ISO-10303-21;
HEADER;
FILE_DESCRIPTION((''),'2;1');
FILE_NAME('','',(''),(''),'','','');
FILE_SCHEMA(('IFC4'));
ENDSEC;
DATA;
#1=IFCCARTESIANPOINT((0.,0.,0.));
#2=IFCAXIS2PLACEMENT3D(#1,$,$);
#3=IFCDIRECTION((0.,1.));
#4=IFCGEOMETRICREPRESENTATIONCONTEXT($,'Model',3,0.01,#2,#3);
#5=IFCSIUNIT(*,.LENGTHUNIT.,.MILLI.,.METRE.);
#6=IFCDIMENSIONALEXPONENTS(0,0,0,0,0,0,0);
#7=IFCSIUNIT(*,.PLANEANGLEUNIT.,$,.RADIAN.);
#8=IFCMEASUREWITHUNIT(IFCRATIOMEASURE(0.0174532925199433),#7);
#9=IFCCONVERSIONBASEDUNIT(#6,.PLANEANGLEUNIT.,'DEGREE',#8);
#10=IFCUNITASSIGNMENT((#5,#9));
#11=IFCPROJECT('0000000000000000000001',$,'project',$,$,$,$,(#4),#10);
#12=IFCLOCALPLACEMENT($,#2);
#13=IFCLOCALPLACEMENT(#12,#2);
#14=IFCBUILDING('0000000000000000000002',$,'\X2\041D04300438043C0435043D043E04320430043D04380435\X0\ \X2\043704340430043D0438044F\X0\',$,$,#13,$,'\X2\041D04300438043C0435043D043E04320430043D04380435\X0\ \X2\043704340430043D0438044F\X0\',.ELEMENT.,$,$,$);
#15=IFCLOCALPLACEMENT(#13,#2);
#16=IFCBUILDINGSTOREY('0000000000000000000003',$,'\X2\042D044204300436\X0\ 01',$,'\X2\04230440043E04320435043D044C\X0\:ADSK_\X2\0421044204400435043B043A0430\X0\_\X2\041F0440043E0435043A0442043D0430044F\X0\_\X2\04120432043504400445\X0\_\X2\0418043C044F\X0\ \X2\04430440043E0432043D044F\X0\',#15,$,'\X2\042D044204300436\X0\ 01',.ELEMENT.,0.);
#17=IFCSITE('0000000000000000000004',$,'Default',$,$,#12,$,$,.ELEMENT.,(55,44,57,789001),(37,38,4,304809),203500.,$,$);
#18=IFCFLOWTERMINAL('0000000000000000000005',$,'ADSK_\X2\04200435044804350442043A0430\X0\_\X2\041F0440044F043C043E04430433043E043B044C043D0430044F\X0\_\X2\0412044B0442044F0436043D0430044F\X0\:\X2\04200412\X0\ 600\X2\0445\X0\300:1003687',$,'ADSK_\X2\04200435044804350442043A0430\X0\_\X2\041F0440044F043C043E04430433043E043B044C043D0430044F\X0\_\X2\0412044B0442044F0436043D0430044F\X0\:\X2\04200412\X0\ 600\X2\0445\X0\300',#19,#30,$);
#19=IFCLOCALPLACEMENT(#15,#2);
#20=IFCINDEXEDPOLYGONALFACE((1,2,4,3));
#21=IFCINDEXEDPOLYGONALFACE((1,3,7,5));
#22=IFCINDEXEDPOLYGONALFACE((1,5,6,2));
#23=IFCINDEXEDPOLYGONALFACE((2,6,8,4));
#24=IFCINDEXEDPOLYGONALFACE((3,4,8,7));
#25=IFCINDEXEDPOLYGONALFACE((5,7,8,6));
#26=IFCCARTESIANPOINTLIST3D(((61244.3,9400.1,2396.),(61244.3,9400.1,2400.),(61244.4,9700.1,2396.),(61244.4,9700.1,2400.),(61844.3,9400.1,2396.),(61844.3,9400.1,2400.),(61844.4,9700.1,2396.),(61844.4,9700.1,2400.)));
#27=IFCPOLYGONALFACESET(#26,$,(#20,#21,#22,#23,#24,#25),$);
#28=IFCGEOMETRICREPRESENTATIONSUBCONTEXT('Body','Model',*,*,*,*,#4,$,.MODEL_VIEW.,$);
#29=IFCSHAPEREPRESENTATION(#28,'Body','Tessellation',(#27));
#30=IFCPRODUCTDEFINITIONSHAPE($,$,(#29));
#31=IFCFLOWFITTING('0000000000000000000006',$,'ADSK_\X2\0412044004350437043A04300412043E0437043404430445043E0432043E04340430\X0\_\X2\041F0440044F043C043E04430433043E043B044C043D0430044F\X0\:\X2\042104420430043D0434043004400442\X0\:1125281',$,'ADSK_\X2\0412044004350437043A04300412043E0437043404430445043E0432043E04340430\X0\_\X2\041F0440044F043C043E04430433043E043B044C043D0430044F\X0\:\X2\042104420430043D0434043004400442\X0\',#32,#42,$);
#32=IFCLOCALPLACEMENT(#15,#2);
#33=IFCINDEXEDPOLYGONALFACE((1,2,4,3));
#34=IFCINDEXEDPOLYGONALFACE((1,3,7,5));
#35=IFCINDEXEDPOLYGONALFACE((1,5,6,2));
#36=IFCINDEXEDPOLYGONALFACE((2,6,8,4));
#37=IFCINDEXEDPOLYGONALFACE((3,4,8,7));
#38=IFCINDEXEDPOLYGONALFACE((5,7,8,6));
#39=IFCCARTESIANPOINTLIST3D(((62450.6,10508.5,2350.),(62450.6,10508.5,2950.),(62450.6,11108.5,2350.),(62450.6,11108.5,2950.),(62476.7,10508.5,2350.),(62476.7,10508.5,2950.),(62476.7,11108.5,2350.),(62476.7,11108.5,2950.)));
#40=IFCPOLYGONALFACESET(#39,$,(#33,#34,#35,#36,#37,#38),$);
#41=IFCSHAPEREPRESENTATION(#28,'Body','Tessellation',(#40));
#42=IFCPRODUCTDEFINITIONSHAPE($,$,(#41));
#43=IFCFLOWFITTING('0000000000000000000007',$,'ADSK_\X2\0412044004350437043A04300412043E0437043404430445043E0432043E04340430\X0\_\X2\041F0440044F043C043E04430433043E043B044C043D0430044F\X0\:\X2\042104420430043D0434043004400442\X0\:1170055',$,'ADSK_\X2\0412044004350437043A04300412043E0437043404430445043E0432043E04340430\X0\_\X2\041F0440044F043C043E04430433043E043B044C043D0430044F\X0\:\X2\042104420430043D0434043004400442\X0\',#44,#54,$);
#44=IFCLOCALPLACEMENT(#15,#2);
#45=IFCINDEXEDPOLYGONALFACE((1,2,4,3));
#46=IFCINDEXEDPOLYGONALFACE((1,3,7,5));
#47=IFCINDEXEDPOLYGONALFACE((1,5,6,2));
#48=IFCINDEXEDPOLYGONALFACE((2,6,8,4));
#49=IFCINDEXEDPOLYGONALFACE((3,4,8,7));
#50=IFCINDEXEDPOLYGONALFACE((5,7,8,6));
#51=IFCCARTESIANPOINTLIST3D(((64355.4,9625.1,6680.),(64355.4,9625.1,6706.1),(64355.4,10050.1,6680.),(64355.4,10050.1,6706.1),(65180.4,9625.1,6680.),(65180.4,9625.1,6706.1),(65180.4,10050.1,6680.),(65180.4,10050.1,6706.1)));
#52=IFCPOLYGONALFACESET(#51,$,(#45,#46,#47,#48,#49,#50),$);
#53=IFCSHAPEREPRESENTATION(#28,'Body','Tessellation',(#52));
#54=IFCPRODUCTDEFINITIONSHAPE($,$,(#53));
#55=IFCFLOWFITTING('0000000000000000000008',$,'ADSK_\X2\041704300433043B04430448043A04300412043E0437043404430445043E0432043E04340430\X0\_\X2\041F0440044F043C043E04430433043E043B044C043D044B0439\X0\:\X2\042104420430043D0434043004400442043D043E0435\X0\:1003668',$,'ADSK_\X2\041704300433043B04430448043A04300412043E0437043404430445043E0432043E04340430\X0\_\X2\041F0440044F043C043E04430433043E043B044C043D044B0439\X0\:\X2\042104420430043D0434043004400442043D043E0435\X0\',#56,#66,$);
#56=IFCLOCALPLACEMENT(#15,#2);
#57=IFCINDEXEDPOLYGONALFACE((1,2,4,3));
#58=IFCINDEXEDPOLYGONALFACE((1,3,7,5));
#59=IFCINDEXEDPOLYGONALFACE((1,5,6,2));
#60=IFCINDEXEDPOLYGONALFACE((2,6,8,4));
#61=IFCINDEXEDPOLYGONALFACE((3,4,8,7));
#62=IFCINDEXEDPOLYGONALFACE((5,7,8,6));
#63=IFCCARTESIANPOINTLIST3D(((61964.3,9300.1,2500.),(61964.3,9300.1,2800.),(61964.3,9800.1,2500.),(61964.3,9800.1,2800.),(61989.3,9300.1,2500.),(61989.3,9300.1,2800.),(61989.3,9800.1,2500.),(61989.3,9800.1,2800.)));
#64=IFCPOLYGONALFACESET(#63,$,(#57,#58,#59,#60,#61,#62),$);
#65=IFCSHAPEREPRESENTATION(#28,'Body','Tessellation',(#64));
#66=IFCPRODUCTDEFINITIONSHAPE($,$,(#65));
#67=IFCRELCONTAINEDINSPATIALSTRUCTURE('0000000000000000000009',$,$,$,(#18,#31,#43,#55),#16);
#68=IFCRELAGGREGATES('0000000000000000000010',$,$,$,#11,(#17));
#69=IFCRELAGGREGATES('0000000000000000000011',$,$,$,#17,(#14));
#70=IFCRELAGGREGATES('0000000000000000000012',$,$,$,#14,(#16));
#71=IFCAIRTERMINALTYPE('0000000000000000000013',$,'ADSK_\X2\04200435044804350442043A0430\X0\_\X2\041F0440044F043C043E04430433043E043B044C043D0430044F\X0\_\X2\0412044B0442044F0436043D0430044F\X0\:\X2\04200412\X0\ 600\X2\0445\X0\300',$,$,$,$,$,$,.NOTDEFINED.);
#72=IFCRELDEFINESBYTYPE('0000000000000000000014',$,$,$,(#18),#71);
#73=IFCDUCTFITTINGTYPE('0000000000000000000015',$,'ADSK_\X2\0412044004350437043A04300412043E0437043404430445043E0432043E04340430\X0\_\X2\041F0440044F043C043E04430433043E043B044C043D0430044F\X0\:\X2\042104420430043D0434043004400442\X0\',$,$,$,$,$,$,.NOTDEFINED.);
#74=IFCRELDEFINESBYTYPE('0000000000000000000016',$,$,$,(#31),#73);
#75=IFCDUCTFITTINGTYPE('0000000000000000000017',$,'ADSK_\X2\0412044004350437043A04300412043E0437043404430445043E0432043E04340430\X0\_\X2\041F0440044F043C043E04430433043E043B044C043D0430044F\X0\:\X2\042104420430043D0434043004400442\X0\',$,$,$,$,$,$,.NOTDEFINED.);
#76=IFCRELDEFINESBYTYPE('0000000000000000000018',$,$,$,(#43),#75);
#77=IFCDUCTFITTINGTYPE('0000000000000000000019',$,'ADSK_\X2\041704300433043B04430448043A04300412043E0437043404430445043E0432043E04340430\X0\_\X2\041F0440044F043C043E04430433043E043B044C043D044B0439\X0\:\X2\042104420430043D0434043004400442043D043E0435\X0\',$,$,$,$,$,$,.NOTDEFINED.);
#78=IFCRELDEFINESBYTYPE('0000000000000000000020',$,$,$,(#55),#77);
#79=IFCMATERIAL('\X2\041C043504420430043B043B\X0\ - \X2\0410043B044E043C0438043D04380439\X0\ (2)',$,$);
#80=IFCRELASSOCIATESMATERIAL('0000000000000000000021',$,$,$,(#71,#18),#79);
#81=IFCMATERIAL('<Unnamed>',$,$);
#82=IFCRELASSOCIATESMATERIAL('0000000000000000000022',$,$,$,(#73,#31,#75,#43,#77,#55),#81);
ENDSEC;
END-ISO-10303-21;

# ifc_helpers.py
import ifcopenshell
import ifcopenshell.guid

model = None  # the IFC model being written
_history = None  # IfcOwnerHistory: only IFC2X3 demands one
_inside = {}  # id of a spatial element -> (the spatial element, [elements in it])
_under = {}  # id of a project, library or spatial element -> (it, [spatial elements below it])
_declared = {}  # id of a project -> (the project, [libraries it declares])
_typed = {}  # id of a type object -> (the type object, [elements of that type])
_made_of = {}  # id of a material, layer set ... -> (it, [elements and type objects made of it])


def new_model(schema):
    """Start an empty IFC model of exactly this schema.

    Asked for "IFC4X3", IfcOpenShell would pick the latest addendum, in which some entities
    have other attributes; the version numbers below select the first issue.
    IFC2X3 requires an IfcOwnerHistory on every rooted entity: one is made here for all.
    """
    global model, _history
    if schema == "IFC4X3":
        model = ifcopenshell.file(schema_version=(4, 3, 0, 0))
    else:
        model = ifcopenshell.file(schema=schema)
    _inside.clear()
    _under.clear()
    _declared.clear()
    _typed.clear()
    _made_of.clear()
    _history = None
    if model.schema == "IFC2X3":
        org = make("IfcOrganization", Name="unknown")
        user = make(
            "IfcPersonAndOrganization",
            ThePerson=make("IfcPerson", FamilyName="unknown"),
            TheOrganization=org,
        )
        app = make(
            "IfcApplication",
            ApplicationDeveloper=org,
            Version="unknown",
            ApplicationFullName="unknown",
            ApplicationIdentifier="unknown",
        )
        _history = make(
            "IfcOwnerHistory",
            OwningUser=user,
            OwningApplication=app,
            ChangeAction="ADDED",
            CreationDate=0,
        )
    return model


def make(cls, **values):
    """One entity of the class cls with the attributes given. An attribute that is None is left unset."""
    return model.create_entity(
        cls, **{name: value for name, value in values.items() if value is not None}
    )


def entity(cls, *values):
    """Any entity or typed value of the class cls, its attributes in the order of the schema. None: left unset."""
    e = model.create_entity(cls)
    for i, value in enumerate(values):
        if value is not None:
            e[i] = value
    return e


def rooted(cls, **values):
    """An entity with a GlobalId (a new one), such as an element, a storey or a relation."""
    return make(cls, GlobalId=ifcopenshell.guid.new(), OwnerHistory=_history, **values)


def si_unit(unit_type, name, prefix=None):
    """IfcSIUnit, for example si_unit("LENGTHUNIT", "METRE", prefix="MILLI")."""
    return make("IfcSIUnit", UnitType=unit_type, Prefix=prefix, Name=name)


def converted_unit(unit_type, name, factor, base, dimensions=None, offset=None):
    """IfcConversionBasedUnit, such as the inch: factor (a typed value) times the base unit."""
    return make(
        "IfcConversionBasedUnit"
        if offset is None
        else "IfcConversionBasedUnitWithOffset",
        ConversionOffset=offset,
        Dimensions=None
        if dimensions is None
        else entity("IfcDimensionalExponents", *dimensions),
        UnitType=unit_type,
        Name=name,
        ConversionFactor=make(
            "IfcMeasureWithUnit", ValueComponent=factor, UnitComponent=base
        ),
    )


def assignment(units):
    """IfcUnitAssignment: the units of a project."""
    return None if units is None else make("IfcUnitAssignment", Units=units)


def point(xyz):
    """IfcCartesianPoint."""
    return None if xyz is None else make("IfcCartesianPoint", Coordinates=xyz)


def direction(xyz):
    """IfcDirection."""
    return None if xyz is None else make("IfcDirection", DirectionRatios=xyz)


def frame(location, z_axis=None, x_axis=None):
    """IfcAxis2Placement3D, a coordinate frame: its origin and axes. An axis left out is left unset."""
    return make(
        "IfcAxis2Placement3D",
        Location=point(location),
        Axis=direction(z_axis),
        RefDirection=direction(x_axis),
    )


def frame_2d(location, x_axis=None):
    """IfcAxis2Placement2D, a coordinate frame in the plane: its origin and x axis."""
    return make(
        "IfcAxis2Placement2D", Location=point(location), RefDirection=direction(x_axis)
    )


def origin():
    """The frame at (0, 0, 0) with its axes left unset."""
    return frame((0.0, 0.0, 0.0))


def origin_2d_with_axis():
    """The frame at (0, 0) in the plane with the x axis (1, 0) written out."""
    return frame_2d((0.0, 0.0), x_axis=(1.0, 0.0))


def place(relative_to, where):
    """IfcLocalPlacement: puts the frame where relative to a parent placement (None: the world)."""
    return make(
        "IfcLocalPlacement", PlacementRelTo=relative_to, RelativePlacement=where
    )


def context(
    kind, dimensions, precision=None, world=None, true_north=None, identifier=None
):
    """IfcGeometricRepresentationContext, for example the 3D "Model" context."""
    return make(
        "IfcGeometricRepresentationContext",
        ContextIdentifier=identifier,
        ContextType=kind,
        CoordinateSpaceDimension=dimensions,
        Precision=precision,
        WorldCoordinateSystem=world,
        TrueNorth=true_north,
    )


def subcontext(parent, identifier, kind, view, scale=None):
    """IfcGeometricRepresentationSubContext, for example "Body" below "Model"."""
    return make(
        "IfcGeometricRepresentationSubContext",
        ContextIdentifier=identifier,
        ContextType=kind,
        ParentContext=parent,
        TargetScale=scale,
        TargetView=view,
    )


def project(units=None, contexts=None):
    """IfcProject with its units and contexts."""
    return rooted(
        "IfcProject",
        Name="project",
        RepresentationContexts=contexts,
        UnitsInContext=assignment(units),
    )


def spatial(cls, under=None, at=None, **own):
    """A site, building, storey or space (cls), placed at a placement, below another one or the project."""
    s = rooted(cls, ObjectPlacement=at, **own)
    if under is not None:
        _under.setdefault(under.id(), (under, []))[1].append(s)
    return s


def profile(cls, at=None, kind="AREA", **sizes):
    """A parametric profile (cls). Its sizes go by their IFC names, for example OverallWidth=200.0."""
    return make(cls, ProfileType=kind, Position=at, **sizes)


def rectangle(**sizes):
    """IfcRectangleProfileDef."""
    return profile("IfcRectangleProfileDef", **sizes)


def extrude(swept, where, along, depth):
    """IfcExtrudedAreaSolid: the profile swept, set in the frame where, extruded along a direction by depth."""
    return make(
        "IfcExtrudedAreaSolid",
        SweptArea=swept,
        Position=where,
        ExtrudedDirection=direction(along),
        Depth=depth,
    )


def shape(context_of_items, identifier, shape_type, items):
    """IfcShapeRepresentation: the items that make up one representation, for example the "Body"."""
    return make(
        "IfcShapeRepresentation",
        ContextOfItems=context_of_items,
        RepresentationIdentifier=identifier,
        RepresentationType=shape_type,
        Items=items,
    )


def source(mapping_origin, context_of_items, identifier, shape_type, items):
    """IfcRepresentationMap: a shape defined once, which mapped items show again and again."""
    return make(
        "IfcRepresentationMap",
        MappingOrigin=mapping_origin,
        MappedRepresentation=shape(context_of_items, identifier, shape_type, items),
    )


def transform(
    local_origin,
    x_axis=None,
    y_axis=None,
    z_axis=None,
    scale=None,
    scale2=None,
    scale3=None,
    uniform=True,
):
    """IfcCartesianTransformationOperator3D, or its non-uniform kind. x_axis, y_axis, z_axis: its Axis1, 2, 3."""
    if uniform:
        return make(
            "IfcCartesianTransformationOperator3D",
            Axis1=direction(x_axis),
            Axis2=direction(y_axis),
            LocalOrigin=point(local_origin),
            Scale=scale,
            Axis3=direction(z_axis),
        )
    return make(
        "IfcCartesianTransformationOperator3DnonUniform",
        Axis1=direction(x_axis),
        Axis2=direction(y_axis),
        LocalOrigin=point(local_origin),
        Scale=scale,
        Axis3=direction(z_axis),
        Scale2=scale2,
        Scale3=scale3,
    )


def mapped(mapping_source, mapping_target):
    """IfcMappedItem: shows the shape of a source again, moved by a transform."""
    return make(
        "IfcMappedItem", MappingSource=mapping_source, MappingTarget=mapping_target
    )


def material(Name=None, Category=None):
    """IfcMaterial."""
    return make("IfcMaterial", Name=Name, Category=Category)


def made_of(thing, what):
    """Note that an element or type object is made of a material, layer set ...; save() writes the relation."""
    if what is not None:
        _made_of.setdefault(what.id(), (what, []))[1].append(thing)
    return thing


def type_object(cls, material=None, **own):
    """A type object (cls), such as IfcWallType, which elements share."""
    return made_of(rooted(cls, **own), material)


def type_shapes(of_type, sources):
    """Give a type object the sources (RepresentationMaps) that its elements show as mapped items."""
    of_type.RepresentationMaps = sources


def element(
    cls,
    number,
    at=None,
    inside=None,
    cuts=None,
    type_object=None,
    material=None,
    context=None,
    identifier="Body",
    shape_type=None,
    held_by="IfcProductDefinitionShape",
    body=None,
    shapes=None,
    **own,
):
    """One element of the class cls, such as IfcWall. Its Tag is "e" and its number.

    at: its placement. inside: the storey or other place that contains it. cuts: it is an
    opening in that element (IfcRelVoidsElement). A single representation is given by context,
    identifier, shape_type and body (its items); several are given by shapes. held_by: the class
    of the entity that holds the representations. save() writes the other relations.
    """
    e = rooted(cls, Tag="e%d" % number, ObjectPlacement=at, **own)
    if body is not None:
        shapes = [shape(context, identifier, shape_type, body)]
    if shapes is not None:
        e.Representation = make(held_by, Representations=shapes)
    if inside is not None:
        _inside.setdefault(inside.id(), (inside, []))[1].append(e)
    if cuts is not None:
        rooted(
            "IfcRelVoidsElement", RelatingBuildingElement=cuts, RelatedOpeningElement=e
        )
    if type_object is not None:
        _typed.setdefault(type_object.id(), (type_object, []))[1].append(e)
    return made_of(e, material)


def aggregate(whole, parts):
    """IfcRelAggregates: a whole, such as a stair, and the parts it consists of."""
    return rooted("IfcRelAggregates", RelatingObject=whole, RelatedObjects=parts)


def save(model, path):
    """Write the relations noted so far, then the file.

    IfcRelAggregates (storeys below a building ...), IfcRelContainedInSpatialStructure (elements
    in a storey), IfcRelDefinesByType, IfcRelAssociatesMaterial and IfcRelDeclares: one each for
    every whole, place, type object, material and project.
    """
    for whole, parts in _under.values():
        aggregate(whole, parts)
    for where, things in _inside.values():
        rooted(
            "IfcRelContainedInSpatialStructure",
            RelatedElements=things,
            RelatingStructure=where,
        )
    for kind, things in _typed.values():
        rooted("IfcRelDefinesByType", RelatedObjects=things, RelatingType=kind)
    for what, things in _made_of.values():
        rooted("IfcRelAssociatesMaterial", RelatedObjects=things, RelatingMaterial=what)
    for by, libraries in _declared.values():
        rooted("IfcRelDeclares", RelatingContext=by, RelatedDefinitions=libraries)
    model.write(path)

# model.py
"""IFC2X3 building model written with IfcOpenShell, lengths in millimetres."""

from ifc_helpers import new_model, entity, si_unit, converted_unit, direction, frame, origin, origin_2d_with_axis, place, context, subcontext, project, spatial, rectangle, extrude, source, transform, mapped, material, type_object, type_shapes, element, save


model = new_model("IFC2X3")

# Units and contexts
model_context = context("Model", 3, precision=0.01, world=origin(), true_north=direction((0.0, 1.0)))
body_context = subcontext(model_context, "Body", "Model", "MODEL_VIEW")
ifc_project = project(units=[si_unit("LENGTHUNIT", "METRE", prefix="MILLI"), converted_unit("PLANEANGLEUNIT", "DEGREE", entity("IfcRatioMeasure", 0.0174532925199433), si_unit("PLANEANGLEUNIT", "RADIAN"), dimensions=[0, 0, 0, 0, 0, 0, 0])], contexts=[model_context])

# Site, building, storey
site_placement = place(None, origin())
site = spatial("IfcSite", under=ifc_project, at=site_placement, Name="Default", CompositionType="ELEMENT", RefLatitude=(55, 44, 57, 789001), RefLongitude=(37, 38, 4, 304809), RefElevation=203500.0)
building_placement = place(site_placement, origin())
building = spatial("IfcBuilding", under=site, at=building_placement, Name="Наименование здания", LongName="Наименование здания", CompositionType="ELEMENT")
storey_placement = place(building_placement, origin())
storey = spatial("IfcBuildingStorey", under=building, at=storey_placement, Name="Этаж 01", ObjectType="Уровень:ADSK_Стрелка_Проектная_Вверх_Имя уровня", LongName="Этаж 01", CompositionType="ELEMENT", Elevation=0.0)

# Shared definitions
ifc_material_1 = material(Name="<Unnamed>")

# Flow terminal
ifc_material_2 = material(Name="Металл - Алюминий (2)")
air_terminal_type = type_object("IfcAirTerminalType", Name="ADSK_Решетка_Прямоугольная_Вытяжная:РВ 600х300", PredefinedType="NOTDEFINED", material=ifc_material_2)
shared_shape_1 = source(origin(), body_context, "Body", "SweptSolid", [
    extrude(rectangle(XDim=4.0, YDim=600.0, at=origin_2d_with_axis()), frame((0.0, -2.0, -150.0), z_axis=(0.0, 0.0, 1.0), x_axis=(0.0, 1.0, 0.0)), (0.0, 0.0, 1.0), 300.0),
])
type_shapes(air_terminal_type, [shared_shape_1])
flow_terminal_placement = place(storey_placement, frame((61544.3, 9550.1, 2400.0), z_axis=(0.000005, 1.0, 0.0), x_axis=(-1.0, 0.000005, 0.0)))
element("IfcFlowTerminal", 1, at=flow_terminal_placement, inside=storey, type_object=air_terminal_type, material=ifc_material_2, Name="ADSK_Решетка_Прямоугольная_Вытяжная:РВ 600х300:1003687", ObjectType="ADSK_Решетка_Прямоугольная_Вытяжная:РВ 600х300", context=body_context, shape_type="MappedRepresentation", body=[
    mapped(shared_shape_1, transform((0.0, 0.0, 0.0), scale=1.0)),
])

# Flow fittings
duct_fitting_type_1 = type_object("IfcDuctFittingType", Name="ADSK_ВрезкаВоздуховода_Прямоугольная:Стандарт", PredefinedType="NOTDEFINED", material=ifc_material_1)
shared_shape_2 = source(origin(), body_context, "Body", "SweptSolid", [
    extrude(rectangle(XDim=600.0, YDim=26.1, at=origin_2d_with_axis()), frame((7.0, 0.0, -300.0), z_axis=(0.0, 0.0, 1.0), x_axis=(0.0, -1.0, 0.0)), (0.0, 0.0, 1.0), 600.0),
])
type_shapes(duct_fitting_type_1, [shared_shape_2])
flow_fitting_1_placement = place(storey_placement, frame((62470.6, 10808.5, 2650.0), z_axis=(0.0, 1.0, 0.0), x_axis=(-1.0, 0.0, 0.0)))
element("IfcFlowFitting", 2, at=flow_fitting_1_placement, inside=storey, type_object=duct_fitting_type_1, material=ifc_material_1, Name="ADSK_ВрезкаВоздуховода_Прямоугольная:Стандарт:1125281", ObjectType="ADSK_ВрезкаВоздуховода_Прямоугольная:Стандарт", context=body_context, shape_type="MappedRepresentation", body=[
    mapped(shared_shape_2, transform((0.0, 0.0, 0.0), scale=1.0)),
])
duct_fitting_type_2 = type_object("IfcDuctFittingType", Name="ADSK_ВрезкаВоздуховода_Прямоугольная:Стандарт", PredefinedType="NOTDEFINED", material=ifc_material_1)
shared_shape_3 = source(origin(), body_context, "Body", "SweptSolid", [
    extrude(rectangle(XDim=425.0, YDim=26.1, at=origin_2d_with_axis()), frame((7.0, 0.0, -412.5), z_axis=(0.0, 0.0, 1.0), x_axis=(0.0, -1.0, 0.0)), (0.0, 0.0, 1.0), 825.0),
])
type_shapes(duct_fitting_type_2, [shared_shape_3])
flow_fitting_2_placement = place(storey_placement, frame((64767.9, 9837.6, 6700.0), z_axis=(1.0, 0.0, 0.0), x_axis=(0.0, 0.0, -1.0)))
element("IfcFlowFitting", 3, at=flow_fitting_2_placement, inside=storey, type_object=duct_fitting_type_2, material=ifc_material_1, Name="ADSK_ВрезкаВоздуховода_Прямоугольная:Стандарт:1170055", ObjectType="ADSK_ВрезкаВоздуховода_Прямоугольная:Стандарт", context=body_context, shape_type="MappedRepresentation", body=[
    mapped(shared_shape_3, transform((0.0, 0.0, 0.0), scale=1.0)),
])
duct_fitting_type_3 = type_object("IfcDuctFittingType", Name="ADSK_ЗаглушкаВоздуховода_Прямоугольный:Стандартное", PredefinedType="NOTDEFINED", material=ifc_material_1)
shared_shape_4 = source(origin(), body_context, "Body", "SweptSolid", [
    extrude(rectangle(XDim=25.0, YDim=500.0, at=origin_2d_with_axis()), frame((12.5, 0.0, -150.0)), (0.0, 0.0, 1.0), 300.0),
])
type_shapes(duct_fitting_type_3, [shared_shape_4])
flow_fitting_3_placement = place(storey_placement, frame((61964.3, 9550.1, 2650.0)))
element("IfcFlowFitting", 4, at=flow_fitting_3_placement, inside=storey, type_object=duct_fitting_type_3, material=ifc_material_1, Name="ADSK_ЗаглушкаВоздуховода_Прямоугольный:Стандартное:1003668", ObjectType="ADSK_ЗаглушкаВоздуховода_Прямоугольный:Стандартное", context=body_context, shape_type="MappedRepresentation", body=[
    mapped(shared_shape_4, transform((0.0, 0.0, 0.0), scale=1.0)),
])

save(model, "model.ifc")
